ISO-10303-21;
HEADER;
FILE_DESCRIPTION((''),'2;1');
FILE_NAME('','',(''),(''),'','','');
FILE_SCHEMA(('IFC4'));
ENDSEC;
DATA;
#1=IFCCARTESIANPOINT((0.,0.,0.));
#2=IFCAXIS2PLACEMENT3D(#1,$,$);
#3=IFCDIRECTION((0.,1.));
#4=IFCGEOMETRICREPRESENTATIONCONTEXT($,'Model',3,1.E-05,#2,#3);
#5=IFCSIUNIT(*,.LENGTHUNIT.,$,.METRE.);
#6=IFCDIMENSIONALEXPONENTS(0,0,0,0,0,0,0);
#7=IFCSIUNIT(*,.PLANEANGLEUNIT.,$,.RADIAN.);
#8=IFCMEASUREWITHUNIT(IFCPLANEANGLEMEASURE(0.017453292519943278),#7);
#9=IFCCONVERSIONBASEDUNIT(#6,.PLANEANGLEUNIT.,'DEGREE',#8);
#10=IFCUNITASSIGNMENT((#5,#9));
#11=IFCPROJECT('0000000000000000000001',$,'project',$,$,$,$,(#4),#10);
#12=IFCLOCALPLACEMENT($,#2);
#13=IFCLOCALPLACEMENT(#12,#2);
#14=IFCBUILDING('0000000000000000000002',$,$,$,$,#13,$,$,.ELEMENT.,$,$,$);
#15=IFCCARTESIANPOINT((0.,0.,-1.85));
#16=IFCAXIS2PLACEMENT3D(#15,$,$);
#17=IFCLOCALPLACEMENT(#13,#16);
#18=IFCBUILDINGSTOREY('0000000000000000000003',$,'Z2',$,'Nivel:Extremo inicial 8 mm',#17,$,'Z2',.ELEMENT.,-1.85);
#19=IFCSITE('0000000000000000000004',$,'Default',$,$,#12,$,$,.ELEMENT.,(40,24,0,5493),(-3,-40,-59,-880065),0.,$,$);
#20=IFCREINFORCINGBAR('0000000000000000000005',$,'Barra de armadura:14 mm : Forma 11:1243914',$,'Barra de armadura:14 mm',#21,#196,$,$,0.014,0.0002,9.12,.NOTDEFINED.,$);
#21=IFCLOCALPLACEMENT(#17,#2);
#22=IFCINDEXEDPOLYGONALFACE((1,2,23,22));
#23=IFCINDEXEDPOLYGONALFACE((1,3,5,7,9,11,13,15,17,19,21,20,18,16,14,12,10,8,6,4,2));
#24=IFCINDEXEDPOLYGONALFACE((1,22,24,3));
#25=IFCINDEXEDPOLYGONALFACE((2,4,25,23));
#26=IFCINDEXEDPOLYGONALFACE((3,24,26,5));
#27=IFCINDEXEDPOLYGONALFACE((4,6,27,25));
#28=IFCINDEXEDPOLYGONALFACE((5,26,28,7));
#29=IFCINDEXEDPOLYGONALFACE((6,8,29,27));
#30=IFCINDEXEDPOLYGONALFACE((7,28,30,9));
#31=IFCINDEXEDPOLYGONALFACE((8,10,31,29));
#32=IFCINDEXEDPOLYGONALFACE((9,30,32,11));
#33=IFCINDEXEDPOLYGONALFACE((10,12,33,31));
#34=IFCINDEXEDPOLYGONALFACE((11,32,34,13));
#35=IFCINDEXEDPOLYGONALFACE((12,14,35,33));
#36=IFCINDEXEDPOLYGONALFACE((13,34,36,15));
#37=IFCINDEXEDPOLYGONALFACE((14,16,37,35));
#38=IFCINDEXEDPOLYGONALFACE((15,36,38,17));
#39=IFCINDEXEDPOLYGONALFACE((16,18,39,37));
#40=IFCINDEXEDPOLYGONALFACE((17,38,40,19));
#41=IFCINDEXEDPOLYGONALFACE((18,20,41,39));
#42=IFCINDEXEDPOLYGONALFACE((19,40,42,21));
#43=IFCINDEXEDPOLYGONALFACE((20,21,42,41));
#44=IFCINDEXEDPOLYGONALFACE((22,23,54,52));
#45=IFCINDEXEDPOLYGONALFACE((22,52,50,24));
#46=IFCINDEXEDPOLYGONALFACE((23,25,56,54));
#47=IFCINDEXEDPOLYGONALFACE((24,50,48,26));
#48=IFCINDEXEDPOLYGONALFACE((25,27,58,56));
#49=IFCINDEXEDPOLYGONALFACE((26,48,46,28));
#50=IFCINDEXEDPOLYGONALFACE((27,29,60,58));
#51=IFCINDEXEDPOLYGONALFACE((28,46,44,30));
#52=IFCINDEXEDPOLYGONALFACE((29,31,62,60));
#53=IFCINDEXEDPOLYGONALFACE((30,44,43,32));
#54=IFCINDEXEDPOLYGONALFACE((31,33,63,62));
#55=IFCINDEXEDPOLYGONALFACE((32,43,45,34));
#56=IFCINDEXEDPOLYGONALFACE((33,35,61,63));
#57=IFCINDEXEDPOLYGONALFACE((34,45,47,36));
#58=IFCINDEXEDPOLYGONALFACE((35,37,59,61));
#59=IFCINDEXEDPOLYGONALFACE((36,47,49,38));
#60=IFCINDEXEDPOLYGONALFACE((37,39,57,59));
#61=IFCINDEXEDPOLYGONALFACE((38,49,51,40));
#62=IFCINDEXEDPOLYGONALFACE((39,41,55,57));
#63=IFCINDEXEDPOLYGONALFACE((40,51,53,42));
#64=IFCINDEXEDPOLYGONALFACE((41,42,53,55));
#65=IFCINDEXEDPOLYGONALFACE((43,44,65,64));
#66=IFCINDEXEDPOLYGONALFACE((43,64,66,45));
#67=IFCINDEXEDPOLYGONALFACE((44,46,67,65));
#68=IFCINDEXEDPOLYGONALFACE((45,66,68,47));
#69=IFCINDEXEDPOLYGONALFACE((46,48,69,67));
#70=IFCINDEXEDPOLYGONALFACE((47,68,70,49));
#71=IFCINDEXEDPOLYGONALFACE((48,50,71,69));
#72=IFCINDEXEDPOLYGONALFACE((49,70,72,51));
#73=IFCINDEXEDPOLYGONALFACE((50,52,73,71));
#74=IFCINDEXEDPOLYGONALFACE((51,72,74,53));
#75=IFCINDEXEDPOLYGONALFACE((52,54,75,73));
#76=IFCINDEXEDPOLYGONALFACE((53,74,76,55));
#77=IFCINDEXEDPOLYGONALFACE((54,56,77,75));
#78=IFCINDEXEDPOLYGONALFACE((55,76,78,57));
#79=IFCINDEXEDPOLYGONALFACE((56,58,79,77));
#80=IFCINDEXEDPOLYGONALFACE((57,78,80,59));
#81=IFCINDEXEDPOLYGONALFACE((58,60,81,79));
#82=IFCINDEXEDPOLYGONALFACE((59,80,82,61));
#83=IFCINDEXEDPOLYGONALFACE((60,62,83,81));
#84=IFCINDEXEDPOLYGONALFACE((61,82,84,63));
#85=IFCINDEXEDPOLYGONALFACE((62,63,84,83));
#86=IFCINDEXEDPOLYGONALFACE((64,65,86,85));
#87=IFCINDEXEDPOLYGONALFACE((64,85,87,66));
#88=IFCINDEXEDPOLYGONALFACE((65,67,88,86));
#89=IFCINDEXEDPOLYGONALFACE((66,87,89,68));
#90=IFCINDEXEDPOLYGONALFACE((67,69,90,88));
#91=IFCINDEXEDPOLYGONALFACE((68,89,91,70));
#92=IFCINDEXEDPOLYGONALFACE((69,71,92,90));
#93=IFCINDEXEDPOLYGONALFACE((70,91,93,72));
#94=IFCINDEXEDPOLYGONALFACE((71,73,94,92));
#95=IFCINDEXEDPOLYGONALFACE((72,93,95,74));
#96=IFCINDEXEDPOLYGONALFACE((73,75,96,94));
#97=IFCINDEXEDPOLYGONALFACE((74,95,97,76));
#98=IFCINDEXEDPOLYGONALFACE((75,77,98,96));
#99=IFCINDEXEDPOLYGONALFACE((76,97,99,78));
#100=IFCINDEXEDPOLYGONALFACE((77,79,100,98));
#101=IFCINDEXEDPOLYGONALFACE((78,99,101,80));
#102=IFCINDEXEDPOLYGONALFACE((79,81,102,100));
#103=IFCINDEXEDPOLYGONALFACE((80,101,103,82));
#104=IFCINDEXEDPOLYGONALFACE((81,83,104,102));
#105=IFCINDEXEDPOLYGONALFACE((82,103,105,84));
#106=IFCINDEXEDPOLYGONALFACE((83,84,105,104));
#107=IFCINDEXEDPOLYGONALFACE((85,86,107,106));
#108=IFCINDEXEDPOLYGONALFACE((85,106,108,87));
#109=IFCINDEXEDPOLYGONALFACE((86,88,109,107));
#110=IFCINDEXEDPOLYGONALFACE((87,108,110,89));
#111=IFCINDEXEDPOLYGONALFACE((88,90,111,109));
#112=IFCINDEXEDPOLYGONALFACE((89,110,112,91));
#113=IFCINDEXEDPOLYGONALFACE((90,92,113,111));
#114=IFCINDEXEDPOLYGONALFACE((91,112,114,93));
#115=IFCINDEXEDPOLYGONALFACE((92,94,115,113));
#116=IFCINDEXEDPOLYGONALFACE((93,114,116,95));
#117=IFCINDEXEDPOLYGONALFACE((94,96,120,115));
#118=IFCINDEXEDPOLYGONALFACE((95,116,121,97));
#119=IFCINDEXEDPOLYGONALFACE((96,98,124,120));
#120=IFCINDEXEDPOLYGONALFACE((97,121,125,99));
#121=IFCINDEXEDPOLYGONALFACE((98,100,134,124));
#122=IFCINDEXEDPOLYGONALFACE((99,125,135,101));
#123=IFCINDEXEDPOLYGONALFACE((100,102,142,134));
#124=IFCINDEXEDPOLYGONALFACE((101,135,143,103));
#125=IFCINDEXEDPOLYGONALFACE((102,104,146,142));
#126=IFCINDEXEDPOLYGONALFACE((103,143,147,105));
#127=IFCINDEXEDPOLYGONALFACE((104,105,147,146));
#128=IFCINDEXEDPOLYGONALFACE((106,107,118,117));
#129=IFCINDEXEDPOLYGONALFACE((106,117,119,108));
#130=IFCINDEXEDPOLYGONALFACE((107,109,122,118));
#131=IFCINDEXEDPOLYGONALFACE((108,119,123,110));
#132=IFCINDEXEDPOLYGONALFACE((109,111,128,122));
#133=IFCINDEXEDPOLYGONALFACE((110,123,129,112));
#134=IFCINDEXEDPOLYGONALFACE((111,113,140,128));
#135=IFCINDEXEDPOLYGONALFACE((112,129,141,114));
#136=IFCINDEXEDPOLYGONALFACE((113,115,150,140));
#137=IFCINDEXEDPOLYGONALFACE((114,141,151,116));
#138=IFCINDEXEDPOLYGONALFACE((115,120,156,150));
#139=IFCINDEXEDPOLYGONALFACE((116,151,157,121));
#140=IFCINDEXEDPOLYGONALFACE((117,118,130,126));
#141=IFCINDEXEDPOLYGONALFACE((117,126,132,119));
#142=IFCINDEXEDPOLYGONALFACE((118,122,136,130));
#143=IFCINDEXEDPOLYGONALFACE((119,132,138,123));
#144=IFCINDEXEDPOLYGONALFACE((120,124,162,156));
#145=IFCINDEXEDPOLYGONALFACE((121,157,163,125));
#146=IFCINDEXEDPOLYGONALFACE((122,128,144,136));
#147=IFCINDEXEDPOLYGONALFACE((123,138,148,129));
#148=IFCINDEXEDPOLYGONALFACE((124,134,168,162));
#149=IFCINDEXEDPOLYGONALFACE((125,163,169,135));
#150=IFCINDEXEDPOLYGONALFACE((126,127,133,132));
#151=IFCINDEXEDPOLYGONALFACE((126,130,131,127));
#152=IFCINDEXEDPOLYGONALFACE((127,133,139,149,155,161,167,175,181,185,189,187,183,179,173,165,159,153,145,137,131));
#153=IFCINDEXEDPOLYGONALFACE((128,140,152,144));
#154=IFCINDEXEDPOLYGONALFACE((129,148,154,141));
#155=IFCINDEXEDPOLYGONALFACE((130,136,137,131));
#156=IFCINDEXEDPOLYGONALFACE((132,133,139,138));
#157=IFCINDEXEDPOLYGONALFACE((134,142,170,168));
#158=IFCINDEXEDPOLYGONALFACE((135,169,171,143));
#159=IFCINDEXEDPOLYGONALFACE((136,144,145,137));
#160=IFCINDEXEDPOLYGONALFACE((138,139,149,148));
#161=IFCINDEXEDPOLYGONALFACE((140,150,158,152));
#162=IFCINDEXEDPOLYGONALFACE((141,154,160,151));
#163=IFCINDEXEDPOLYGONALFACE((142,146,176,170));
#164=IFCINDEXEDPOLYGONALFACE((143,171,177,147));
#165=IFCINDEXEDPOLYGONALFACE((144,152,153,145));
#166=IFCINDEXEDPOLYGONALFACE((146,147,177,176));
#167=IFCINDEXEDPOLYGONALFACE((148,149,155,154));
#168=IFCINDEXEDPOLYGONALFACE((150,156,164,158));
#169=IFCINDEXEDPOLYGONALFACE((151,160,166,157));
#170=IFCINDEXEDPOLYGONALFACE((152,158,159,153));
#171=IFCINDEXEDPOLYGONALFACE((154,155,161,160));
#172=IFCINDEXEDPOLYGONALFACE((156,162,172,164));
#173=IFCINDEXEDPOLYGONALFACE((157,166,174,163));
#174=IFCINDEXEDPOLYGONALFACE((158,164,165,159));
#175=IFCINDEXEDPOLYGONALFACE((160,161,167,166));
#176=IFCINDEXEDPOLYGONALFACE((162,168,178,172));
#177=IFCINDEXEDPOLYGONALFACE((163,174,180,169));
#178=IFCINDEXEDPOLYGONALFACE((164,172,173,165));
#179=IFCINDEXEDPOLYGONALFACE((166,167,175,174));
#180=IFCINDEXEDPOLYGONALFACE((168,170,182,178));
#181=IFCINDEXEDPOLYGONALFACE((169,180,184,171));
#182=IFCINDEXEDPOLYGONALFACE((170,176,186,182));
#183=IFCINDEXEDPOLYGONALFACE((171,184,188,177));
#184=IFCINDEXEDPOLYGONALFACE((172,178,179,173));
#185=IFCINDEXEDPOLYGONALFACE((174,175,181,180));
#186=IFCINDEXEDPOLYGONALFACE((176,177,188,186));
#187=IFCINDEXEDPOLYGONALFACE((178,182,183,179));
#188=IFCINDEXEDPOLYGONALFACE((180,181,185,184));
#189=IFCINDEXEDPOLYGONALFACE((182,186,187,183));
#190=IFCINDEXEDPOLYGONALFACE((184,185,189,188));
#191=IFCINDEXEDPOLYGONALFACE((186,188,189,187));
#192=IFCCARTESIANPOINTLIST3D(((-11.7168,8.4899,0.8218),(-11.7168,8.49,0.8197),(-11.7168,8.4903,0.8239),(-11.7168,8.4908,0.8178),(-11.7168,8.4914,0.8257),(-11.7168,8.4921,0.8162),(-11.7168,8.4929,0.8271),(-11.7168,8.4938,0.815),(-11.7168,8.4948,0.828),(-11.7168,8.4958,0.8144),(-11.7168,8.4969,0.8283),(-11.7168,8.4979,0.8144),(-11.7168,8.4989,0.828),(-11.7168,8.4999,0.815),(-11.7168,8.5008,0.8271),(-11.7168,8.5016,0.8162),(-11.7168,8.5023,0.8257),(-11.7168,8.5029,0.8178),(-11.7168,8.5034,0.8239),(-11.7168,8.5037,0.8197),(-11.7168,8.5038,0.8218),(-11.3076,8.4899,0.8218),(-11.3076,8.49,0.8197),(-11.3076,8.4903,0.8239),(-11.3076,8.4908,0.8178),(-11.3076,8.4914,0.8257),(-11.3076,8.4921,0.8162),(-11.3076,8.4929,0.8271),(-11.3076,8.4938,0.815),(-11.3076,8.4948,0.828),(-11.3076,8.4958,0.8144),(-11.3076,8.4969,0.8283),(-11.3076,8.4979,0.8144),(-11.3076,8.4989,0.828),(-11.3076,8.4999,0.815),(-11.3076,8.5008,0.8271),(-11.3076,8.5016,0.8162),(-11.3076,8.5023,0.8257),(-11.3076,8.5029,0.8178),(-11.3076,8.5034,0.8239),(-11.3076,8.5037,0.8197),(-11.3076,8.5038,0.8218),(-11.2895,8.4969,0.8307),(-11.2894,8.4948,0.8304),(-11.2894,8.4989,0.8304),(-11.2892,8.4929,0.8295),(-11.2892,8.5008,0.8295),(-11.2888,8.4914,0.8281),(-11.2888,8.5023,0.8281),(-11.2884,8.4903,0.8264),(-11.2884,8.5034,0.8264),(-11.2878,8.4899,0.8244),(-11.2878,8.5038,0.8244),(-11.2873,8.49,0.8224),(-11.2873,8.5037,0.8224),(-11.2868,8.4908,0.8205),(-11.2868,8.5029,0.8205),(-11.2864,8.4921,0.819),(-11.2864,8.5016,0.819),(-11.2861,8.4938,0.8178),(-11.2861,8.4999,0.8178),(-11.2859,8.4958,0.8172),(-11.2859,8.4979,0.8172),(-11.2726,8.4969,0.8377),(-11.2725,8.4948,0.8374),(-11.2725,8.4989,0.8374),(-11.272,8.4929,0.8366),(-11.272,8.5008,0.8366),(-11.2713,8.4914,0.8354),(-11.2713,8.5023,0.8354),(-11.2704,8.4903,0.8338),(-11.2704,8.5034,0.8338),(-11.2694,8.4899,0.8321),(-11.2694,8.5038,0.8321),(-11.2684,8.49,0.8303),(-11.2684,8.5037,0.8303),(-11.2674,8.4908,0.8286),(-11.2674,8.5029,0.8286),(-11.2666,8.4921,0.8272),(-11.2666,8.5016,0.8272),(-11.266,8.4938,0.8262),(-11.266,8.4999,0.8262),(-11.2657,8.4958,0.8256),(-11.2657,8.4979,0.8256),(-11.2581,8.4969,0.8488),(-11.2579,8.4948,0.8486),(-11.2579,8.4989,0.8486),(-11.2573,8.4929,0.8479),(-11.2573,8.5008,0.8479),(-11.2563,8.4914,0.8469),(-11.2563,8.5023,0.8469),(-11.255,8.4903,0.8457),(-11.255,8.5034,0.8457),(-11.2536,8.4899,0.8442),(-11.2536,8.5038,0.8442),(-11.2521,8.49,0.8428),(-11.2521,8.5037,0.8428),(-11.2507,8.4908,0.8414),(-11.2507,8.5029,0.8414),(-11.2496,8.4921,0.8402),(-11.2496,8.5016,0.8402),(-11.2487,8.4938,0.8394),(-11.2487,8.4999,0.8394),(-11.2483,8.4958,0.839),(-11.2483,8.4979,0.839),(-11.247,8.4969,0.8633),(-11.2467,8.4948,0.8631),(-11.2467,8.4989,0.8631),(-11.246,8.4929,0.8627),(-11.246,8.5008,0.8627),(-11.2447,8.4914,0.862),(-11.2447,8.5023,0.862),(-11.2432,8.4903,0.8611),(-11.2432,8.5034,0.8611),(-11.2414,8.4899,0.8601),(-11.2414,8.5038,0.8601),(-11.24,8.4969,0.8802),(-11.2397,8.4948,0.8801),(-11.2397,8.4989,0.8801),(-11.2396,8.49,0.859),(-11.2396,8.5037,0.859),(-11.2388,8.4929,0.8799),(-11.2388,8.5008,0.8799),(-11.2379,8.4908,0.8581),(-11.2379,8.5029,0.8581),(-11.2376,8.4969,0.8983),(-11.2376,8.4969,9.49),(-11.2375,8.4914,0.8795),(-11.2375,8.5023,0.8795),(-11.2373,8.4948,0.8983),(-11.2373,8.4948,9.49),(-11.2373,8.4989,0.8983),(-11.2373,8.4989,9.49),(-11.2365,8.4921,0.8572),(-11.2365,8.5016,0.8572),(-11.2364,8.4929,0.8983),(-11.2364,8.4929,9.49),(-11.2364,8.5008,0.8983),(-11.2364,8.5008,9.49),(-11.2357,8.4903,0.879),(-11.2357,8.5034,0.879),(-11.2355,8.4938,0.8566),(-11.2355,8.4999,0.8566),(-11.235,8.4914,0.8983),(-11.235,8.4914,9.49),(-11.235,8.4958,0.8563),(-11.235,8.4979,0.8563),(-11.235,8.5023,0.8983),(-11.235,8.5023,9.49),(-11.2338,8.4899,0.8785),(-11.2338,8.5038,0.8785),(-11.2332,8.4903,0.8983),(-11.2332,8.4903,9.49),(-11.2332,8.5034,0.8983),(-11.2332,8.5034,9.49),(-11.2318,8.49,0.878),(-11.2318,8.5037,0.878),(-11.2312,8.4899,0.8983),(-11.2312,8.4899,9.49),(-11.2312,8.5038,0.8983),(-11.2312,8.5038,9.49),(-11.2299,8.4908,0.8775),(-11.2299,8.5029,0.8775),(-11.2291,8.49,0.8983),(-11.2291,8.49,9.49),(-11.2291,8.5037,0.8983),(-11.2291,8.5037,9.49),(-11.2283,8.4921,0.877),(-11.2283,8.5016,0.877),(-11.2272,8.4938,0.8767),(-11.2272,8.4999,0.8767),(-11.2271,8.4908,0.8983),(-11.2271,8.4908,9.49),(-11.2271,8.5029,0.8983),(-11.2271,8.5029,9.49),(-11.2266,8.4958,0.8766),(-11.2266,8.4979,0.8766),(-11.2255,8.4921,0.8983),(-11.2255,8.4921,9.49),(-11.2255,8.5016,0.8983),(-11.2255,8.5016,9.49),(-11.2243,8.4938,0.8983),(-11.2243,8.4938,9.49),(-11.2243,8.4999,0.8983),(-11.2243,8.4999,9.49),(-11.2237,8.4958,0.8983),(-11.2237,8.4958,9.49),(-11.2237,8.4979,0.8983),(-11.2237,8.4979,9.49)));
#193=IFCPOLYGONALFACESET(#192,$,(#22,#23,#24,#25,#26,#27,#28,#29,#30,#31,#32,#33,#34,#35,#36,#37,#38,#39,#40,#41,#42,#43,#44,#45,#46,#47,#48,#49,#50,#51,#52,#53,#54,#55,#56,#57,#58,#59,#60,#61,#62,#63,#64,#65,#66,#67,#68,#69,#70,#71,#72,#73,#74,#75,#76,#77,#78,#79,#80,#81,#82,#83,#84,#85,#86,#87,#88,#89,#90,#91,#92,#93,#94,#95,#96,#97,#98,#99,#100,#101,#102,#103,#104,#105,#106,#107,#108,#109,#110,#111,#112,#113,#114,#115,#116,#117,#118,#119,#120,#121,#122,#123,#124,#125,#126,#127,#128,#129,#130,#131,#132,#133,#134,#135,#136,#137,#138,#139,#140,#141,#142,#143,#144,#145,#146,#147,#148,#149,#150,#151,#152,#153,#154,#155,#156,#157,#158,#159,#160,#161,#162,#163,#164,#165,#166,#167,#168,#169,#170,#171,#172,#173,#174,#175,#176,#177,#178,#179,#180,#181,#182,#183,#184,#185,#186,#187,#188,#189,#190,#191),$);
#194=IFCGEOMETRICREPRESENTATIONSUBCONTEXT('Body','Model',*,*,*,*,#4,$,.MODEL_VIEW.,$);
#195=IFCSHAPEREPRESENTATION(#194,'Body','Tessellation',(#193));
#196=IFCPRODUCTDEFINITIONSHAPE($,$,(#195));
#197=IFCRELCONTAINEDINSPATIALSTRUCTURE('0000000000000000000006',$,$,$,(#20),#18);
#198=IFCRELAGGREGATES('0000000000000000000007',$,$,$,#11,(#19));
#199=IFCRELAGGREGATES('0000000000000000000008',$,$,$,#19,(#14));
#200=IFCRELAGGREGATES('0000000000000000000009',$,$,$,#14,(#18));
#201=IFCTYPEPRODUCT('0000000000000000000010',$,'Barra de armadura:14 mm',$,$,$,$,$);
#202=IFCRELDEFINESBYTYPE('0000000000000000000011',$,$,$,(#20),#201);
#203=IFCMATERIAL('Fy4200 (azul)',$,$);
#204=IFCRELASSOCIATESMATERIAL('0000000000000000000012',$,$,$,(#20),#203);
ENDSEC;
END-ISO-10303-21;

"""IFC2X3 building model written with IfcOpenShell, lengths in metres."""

from ifc_helpers import new_model, entity, si_unit, converted_unit, direction, frame, origin, place, context, subcontext, project, spatial, material, type_object, element, save


model = new_model("IFC2X3")

# Units and contexts
model_context = context("Model", 3, precision=1e-05, world=origin(), true_north=direction((0.0, 1.0)))
body_context = subcontext(model_context, "Body", "Model", "MODEL_VIEW")
ifc_project = project(units=[si_unit("LENGTHUNIT", "METRE"), converted_unit("PLANEANGLEUNIT", "DEGREE", entity("IfcPlaneAngleMeasure", 0.017453292519943278), si_unit("PLANEANGLEUNIT", "RADIAN"), dimensions=[0, 0, 0, 0, 0, 0, 0])], contexts=[model_context])

# Site, building, storey
site_placement = place(None, origin())
site = spatial("IfcSite", under=ifc_project, at=site_placement, Name="Default", CompositionType="ELEMENT", RefLatitude=(40, 24, 0, 5493), RefLongitude=(-3, -40, -59, -880065), RefElevation=0.0)
building_placement = place(site_placement, origin())
building = spatial("IfcBuilding", under=site, at=building_placement, CompositionType="ELEMENT")
storey_placement = place(building_placement, frame((0.0, 0.0, -1.85)))
storey = spatial("IfcBuildingStorey", under=building, at=storey_placement, Name="Z2", ObjectType="Nivel:Extremo inicial 8 mm", LongName="Z2", CompositionType="ELEMENT", Elevation=-1.85)

# Reinforcing bar
ifc_material_1 = material(Name="Fy4200 (azul)")
type_product_1 = type_object("IfcTypeProduct", Name="Barra de armadura:14 mm")
reinforcing_bar_1_placement = place(storey_placement, origin())
element("IfcReinforcingBar", 1, at=reinforcing_bar_1_placement, inside=storey, type_object=type_product_1, material=ifc_material_1, Name="Barra de armadura:14 mm : Forma 11:1243914", ObjectType="Barra de armadura:14 mm", BarLength=9.12, BarRole="NOTDEFINED", CrossSectionArea=0.0002, NominalDiameter=0.014, context=body_context, shape_type="AdvancedSweptSolid", body=[
    entity("IfcSweptDiskSolid", entity("IfcCompositeCurve", [entity("IfcCompositeCurveSegment", "CONTINUOUS", True, entity("IfcPolyline", [entity("IfcCartesianPoint", [-11.2306, 8.4969, 9.49]), entity("IfcCartesianPoint", [-11.2306, 8.4969, 0.8983])])), entity("IfcCompositeCurveSegment", "CONTINUOUS", True, entity("IfcTrimmedCurve", entity("IfcCircle", entity("IfcAxis2Placement3D", entity("IfcCartesianPoint", [-11.3076, 8.4969, 0.8983]), entity("IfcDirection", [0.0, 1.0, 0.0]), entity("IfcDirection", [0.0, 0.0, -1.0])), 0.077), [entity("IfcParameterValue", 270.0)], [entity("IfcParameterValue", 360.0)], True, "PARAMETER")), entity("IfcCompositeCurveSegment", "CONTINUOUS", True, entity("IfcPolyline", [entity("IfcCartesianPoint", [-11.3076, 8.4969, 0.8213]), entity("IfcCartesianPoint", [-11.7168, 8.4969, 0.8213])]))], False), 0.007, None, 0.0, 92.0),
])

save(model, "model.ifc")
